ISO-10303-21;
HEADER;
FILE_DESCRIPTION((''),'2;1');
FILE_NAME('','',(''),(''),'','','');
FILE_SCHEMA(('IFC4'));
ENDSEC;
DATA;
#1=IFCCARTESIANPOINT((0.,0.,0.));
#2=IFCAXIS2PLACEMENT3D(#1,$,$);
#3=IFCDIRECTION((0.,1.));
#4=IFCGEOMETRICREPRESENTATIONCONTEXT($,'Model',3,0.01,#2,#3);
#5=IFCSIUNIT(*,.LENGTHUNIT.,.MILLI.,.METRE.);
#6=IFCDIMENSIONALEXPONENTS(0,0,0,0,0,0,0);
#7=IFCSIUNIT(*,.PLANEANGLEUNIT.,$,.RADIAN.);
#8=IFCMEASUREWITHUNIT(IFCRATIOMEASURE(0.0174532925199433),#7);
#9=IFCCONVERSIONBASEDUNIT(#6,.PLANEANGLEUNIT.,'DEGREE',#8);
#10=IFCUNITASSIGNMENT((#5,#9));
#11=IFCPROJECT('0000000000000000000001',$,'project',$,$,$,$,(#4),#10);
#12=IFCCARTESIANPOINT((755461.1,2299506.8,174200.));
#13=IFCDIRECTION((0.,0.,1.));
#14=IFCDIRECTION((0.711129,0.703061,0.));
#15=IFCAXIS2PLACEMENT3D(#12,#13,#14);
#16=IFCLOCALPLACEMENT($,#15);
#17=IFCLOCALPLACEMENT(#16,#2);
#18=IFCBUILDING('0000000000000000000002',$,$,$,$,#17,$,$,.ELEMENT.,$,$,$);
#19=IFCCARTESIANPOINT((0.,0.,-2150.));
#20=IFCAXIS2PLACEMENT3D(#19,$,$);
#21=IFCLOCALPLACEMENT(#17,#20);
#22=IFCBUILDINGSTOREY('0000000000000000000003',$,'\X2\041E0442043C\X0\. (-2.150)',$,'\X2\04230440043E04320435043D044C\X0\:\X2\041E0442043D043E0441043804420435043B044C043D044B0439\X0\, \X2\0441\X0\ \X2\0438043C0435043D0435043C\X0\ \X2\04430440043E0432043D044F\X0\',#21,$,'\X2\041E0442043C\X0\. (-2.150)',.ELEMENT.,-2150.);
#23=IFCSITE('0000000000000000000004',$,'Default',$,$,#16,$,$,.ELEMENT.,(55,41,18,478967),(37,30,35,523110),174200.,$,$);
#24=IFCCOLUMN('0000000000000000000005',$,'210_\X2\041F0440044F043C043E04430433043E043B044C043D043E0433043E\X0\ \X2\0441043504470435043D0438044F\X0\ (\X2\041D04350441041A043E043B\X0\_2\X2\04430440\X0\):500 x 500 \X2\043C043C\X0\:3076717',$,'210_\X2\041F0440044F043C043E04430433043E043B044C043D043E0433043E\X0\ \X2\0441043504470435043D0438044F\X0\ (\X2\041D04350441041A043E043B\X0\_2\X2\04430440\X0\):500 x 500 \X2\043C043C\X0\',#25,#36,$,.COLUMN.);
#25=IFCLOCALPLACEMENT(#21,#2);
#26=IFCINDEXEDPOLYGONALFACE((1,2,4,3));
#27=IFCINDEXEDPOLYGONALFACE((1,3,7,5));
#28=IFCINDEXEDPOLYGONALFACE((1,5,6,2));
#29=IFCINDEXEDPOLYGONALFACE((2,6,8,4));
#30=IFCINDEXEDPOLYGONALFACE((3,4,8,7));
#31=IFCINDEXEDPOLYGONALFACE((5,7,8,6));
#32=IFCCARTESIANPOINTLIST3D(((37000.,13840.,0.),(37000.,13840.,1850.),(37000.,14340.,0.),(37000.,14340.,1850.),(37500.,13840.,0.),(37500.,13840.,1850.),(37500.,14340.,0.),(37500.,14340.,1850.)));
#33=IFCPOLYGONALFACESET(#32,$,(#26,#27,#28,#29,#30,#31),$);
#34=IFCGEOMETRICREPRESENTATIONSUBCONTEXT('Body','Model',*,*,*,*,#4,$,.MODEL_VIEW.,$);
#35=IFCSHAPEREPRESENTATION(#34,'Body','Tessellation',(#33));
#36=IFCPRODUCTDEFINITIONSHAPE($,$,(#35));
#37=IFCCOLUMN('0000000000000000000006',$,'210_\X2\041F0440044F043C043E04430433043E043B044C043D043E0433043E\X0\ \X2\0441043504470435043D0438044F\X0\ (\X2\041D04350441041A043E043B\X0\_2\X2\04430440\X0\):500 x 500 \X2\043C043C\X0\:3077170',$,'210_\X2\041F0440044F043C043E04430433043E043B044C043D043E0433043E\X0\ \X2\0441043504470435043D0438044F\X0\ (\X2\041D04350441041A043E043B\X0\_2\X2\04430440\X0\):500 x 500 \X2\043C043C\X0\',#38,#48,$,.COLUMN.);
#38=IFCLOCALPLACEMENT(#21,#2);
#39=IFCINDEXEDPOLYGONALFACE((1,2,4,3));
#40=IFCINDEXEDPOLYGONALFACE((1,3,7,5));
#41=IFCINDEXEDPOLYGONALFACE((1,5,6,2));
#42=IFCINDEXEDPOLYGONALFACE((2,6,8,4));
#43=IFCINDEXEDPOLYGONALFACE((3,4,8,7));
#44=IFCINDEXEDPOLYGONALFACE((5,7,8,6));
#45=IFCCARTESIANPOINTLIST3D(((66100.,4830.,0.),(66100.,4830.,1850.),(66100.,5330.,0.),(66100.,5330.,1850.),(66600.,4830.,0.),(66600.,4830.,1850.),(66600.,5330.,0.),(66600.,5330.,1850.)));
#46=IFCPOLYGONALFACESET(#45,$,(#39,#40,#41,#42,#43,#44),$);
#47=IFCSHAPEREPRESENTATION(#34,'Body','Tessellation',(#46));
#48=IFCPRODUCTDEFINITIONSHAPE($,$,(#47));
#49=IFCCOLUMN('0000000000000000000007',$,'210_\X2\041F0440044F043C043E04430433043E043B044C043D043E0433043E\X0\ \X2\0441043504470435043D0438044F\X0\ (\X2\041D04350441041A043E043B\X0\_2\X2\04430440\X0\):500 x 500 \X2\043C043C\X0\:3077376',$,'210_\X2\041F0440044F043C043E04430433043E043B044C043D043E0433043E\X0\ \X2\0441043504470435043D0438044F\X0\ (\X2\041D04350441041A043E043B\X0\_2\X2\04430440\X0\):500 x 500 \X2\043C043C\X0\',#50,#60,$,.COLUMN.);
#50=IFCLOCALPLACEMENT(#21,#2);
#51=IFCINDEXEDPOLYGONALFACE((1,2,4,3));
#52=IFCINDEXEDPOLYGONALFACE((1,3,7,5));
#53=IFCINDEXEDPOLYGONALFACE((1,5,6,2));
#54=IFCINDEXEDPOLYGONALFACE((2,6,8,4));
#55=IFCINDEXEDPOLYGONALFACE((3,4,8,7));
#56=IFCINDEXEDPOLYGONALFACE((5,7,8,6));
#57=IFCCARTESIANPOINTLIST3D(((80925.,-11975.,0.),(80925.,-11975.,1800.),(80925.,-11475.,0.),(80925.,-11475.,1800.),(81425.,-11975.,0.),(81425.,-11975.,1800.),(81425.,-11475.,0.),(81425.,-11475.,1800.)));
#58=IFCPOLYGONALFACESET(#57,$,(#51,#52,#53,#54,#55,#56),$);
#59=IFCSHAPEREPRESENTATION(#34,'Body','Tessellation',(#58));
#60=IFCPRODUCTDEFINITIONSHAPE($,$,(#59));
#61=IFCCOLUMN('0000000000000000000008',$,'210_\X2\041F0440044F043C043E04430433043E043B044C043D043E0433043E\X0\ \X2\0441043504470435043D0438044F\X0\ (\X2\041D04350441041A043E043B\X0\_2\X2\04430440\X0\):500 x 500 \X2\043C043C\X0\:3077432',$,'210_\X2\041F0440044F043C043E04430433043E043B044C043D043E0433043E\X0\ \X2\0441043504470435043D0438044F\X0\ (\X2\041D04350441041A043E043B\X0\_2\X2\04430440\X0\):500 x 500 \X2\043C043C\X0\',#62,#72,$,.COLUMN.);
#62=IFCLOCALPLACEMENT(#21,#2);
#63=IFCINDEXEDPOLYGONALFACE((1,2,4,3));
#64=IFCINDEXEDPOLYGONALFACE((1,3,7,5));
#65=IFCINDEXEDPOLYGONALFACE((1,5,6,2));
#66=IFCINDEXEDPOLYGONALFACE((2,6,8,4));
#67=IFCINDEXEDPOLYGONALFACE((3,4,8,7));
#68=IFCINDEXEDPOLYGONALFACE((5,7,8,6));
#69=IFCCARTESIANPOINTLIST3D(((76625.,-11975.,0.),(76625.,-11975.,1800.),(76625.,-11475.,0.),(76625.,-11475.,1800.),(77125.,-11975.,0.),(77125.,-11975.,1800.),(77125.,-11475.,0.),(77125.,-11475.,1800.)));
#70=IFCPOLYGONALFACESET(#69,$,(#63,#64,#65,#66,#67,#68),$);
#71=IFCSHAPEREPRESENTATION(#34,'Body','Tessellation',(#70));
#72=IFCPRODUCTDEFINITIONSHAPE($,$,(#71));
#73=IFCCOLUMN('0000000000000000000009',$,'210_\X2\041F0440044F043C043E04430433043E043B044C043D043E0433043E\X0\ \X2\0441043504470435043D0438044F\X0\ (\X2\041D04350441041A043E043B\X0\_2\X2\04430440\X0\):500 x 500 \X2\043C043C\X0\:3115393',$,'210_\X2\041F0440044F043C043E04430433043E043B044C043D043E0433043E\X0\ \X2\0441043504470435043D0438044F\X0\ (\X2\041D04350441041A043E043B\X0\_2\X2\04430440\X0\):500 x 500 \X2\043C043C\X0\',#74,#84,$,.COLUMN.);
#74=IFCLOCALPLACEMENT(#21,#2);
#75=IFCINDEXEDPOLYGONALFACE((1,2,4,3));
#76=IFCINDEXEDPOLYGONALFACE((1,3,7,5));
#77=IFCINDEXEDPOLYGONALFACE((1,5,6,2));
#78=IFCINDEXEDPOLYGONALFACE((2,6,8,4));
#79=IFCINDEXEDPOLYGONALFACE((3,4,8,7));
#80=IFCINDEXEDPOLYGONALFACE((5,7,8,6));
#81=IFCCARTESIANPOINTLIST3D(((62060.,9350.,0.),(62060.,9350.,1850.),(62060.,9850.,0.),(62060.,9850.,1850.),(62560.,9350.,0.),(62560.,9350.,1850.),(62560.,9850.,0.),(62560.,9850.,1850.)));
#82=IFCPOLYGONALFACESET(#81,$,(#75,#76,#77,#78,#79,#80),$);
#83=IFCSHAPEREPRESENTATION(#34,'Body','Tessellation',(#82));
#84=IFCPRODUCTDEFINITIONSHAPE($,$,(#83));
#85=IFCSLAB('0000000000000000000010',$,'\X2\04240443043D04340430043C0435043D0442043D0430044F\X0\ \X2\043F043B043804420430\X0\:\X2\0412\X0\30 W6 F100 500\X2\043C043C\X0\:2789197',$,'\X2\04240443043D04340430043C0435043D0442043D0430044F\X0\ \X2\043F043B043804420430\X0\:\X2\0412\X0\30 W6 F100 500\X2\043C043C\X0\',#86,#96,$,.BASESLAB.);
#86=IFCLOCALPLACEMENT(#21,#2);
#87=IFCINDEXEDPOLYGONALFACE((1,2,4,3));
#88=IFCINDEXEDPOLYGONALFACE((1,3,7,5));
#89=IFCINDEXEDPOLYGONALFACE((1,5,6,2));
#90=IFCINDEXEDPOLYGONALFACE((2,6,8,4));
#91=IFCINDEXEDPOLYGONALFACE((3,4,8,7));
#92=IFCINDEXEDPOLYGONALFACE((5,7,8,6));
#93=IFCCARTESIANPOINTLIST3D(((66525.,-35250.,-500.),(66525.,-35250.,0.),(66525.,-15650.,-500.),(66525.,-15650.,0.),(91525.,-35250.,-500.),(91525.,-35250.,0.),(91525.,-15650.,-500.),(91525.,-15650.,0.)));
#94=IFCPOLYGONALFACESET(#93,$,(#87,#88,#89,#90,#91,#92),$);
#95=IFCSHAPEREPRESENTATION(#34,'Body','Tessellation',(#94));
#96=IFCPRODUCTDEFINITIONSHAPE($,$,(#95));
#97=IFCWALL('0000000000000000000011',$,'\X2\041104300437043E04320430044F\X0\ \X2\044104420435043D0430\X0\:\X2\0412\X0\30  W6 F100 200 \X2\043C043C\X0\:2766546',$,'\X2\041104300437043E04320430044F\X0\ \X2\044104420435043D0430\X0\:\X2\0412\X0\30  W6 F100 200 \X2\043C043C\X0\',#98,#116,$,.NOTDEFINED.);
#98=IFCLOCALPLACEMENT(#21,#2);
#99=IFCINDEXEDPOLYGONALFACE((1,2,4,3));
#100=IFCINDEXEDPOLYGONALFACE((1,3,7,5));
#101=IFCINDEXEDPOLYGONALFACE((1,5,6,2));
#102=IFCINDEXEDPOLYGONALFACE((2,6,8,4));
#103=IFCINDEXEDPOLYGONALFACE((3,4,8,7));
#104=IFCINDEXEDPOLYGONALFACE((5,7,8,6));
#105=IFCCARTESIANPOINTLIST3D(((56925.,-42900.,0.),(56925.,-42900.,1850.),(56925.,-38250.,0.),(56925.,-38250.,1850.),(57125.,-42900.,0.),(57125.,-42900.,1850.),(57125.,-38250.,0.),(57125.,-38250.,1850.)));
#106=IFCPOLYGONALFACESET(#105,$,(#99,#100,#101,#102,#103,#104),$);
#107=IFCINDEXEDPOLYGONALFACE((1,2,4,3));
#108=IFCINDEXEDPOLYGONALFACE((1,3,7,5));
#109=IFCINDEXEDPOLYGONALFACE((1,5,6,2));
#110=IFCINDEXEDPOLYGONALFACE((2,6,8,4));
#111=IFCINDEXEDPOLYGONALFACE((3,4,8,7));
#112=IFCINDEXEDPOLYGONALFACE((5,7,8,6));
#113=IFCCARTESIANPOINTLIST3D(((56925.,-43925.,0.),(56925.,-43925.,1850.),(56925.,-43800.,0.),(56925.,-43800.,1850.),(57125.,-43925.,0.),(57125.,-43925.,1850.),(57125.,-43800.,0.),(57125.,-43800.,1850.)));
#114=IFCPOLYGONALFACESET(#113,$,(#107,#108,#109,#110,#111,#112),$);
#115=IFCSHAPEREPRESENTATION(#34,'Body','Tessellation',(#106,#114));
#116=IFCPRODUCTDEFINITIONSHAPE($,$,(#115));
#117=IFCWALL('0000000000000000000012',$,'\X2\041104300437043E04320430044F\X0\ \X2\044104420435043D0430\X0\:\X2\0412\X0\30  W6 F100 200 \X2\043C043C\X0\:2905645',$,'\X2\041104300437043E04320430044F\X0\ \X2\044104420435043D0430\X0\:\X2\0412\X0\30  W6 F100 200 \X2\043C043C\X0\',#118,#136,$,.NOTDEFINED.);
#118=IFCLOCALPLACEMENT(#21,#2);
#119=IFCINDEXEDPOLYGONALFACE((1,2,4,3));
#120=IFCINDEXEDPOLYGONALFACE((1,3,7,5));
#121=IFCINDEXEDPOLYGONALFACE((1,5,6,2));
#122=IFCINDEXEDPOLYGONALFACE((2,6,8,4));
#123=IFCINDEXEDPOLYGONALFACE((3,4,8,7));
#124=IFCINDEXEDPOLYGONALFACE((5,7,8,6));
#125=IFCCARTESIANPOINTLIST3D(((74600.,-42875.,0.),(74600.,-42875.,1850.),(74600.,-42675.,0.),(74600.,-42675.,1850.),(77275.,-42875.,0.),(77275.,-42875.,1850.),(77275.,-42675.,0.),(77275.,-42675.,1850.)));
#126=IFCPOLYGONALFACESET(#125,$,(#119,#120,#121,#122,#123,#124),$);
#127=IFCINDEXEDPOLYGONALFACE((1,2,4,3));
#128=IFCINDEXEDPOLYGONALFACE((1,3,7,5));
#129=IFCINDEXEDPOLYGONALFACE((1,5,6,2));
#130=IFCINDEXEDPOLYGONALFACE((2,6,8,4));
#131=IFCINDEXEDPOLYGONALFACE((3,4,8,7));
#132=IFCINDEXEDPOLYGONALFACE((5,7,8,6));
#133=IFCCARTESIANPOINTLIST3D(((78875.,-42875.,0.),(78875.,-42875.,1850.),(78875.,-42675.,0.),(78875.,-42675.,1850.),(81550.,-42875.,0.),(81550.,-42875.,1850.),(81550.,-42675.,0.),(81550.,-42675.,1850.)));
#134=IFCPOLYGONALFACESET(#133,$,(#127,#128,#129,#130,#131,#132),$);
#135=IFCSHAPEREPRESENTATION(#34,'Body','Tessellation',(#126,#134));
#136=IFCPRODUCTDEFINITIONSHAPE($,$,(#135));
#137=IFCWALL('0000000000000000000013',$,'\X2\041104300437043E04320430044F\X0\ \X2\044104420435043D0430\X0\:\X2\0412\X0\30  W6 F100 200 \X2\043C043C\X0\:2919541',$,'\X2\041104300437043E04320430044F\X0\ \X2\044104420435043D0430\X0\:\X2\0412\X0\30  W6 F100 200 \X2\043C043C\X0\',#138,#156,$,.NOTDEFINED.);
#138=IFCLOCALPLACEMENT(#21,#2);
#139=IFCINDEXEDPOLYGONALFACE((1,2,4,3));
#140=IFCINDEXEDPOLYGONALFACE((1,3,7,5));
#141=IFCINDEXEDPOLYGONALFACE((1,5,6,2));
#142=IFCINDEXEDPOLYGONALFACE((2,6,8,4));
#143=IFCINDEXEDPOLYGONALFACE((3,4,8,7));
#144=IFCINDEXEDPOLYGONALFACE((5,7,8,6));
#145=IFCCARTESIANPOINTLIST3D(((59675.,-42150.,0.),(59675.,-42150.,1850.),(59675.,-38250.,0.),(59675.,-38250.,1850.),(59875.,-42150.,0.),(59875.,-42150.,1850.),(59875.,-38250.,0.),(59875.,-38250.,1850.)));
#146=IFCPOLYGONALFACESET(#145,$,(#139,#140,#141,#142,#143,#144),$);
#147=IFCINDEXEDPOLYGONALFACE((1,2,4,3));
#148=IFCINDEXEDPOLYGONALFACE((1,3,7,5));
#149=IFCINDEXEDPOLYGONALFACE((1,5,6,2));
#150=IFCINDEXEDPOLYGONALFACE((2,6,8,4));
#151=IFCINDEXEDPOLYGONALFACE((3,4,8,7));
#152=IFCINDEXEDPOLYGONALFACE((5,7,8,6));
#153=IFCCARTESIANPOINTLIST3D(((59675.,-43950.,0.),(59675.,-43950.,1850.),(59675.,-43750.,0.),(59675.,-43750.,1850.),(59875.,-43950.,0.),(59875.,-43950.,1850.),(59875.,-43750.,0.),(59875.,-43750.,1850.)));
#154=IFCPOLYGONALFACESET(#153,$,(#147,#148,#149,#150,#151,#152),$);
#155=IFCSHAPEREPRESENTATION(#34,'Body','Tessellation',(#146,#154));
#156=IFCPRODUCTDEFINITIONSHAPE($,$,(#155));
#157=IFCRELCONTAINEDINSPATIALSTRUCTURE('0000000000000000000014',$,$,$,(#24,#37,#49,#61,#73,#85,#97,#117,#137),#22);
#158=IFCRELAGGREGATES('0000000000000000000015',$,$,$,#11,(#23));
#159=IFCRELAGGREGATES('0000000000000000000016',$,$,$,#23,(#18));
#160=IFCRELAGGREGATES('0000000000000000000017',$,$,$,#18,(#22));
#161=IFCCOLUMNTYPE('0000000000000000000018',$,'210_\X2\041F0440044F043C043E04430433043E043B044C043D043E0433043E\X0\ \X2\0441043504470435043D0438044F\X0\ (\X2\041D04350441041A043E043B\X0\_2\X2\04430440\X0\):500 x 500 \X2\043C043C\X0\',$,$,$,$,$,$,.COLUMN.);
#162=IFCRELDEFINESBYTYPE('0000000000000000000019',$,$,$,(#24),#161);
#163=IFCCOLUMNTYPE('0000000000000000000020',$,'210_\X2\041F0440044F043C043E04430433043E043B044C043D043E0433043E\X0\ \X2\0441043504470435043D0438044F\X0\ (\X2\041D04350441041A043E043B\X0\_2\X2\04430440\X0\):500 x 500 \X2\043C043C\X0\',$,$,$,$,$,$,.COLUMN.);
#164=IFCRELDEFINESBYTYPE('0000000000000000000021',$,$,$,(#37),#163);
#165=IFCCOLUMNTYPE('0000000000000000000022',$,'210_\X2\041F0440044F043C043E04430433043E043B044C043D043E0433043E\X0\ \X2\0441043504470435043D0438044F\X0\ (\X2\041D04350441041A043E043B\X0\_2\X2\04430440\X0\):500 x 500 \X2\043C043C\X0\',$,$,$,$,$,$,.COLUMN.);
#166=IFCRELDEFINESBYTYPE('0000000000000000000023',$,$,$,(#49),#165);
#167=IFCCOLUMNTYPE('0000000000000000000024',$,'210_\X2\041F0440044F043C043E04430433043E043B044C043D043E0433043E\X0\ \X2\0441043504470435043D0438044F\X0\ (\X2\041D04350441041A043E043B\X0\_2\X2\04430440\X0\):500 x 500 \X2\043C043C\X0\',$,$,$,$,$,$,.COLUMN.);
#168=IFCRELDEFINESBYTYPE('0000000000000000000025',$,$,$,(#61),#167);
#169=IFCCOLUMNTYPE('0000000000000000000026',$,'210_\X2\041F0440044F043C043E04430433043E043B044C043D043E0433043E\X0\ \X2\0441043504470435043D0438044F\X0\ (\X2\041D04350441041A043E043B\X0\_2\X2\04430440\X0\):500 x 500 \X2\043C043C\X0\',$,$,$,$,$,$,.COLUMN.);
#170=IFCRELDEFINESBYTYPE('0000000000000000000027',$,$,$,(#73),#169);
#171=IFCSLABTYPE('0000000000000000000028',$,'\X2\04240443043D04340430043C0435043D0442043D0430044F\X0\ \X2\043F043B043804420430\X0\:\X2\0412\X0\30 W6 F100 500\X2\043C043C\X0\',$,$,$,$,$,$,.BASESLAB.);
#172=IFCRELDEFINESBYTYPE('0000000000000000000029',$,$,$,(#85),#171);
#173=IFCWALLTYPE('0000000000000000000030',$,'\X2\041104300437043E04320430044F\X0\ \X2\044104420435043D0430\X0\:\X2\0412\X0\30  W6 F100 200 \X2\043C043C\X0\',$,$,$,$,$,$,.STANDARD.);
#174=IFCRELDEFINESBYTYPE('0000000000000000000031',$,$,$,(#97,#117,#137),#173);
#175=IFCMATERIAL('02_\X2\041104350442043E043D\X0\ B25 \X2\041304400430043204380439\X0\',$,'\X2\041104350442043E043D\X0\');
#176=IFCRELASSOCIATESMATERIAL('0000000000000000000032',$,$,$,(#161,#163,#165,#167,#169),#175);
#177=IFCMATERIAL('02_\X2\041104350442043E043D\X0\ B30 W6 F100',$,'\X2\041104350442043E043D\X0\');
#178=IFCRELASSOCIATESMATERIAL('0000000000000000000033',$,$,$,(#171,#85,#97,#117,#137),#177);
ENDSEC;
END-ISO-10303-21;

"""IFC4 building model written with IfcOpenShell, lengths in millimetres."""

from ifc_helpers import new_model, entity, si_unit, converted_unit, direction, frame, origin, place, context, subcontext, project, spatial, indexed_curve, outline, extrude, source, transform, mapped, material, type_object, type_shapes, element, save


model = new_model("IFC4")

# Units and contexts
model_context = context("Model", 3, precision=0.01, world=origin(), true_north=direction((0.0, 1.0)))
body_context = subcontext(model_context, "Body", "Model", "MODEL_VIEW")
ifc_project = project(units=[si_unit("LENGTHUNIT", "METRE", prefix="MILLI"), converted_unit("PLANEANGLEUNIT", "DEGREE", entity("IfcRatioMeasure", 0.0174532925199433), si_unit("PLANEANGLEUNIT", "RADIAN"), dimensions=[0, 0, 0, 0, 0, 0, 0])], contexts=[model_context])

# Site, building, storey
site_placement = place(None, frame((755461.1, 2299506.8, 174200.0), z_axis=(0.0, 0.0, 1.0), x_axis=(0.711129, 0.703061, 0.0)))
site = spatial("IfcSite", under=ifc_project, at=site_placement, Name="Default", CompositionType="ELEMENT", RefLatitude=(55, 41, 18, 478967), RefLongitude=(37, 30, 35, 523110), RefElevation=174200.0)
building_placement = place(site_placement, origin())
building = spatial("IfcBuilding", under=site, at=building_placement, CompositionType="ELEMENT")
storey_placement = place(building_placement, frame((0.0, 0.0, -2150.0)))
storey = spatial("IfcBuildingStorey", under=building, at=storey_placement, Name="Отм. (-2.150)", ObjectType="Уровень:Относительный, с именем уровня", LongName="Отм. (-2.150)", CompositionType="ELEMENT", Elevation=-2150.0)

# Columns
ifc_material_1 = material(Name="02_Бетон B25 Гравий", Category="Бетон")
column_type_1 = type_object("IfcColumnType", Name="210_Прямоугольного сечения (НесКол_2ур):500 x 500 мм", PredefinedType="COLUMN", material=ifc_material_1)
shared_shape_1 = source(origin(), body_context, "Body", "SweptSolid", [
    extrude(outline(indexed_curve([(-250.0, -250.0), (250.0, -250.0), (250.0, 250.0), (-250.0, 250.0), (-250.0, -250.0)], self_intersect=False)), frame((37250.0, 14090.0, -2150.0), z_axis=(0.0, 0.0, 1.0), x_axis=(0.0, -1.0, 0.0)), (0.0, 0.0, 1.0), 1850.0),
])
type_shapes(column_type_1, [shared_shape_1])
column_1_placement = place(storey_placement, frame((0.0, 0.0, 2150.0)))
element("IfcColumn", 1, at=column_1_placement, inside=storey, type_object=column_type_1, Name="210_Прямоугольного сечения (НесКол_2ур):500 x 500 мм:3076717", ObjectType="210_Прямоугольного сечения (НесКол_2ур):500 x 500 мм", PredefinedType="COLUMN", context=body_context, shape_type="MappedRepresentation", body=[
    mapped(shared_shape_1, transform((0.0, 0.0, 0.0), scale=1.0)),
])
column_type_2 = type_object("IfcColumnType", Name="210_Прямоугольного сечения (НесКол_2ур):500 x 500 мм", PredefinedType="COLUMN", material=ifc_material_1)
shared_shape_2 = source(origin(), body_context, "Body", "SweptSolid", [
    extrude(outline(indexed_curve([(-250.0, -250.0), (250.0, -250.0), (250.0, 250.0), (-250.0, 250.0), (-250.0, -250.0)], self_intersect=False)), frame((66350.0, 5080.0, -2150.0), z_axis=(0.0, 0.0, 1.0), x_axis=(0.0, -1.0, 0.0)), (0.0, 0.0, 1.0), 1850.0),
])
type_shapes(column_type_2, [shared_shape_2])
column_2_placement = place(storey_placement, frame((0.0, 0.0, 2150.0)))
element("IfcColumn", 2, at=column_2_placement, inside=storey, type_object=column_type_2, Name="210_Прямоугольного сечения (НесКол_2ур):500 x 500 мм:3077170", ObjectType="210_Прямоугольного сечения (НесКол_2ур):500 x 500 мм", PredefinedType="COLUMN", context=body_context, shape_type="MappedRepresentation", body=[
    mapped(shared_shape_2, transform((0.0, 0.0, 0.0), scale=1.0)),
])
column_type_3 = type_object("IfcColumnType", Name="210_Прямоугольного сечения (НесКол_2ур):500 x 500 мм", PredefinedType="COLUMN", material=ifc_material_1)
shared_shape_3 = source(origin(), body_context, "Body", "SweptSolid", [
    extrude(outline(indexed_curve([(-250.0, -250.0), (250.0, -250.0), (250.0, 250.0), (-250.0, 250.0), (-250.0, -250.0)], self_intersect=False)), frame((81175.0, -11725.0, -2150.0), z_axis=(0.0, 0.0, 1.0), x_axis=(0.0, -1.0, 0.0)), (0.0, 0.0, 1.0), 1800.0),
])
type_shapes(column_type_3, [shared_shape_3])
column_3_placement = place(storey_placement, frame((0.0, 0.0, 2150.0)))
element("IfcColumn", 3, at=column_3_placement, inside=storey, type_object=column_type_3, Name="210_Прямоугольного сечения (НесКол_2ур):500 x 500 мм:3077376", ObjectType="210_Прямоугольного сечения (НесКол_2ур):500 x 500 мм", PredefinedType="COLUMN", context=body_context, shape_type="MappedRepresentation", body=[
    mapped(shared_shape_3, transform((0.0, 0.0, 0.0), scale=1.0)),
])
column_type_4 = type_object("IfcColumnType", Name="210_Прямоугольного сечения (НесКол_2ур):500 x 500 мм", PredefinedType="COLUMN", material=ifc_material_1)
shared_shape_4 = source(origin(), body_context, "Body", "SweptSolid", [
    extrude(outline(indexed_curve([(-250.0, -250.0), (250.0, -250.0), (250.0, 250.0), (-250.0, 250.0), (-250.0, -250.0)], self_intersect=False)), frame((76875.0, -11725.0, -2150.0), z_axis=(0.0, 0.0, 1.0), x_axis=(0.0, -1.0, 0.0)), (0.0, 0.0, 1.0), 1800.0),
])
type_shapes(column_type_4, [shared_shape_4])
column_4_placement = place(storey_placement, frame((0.0, 0.0, 2150.0)))
element("IfcColumn", 4, at=column_4_placement, inside=storey, type_object=column_type_4, Name="210_Прямоугольного сечения (НесКол_2ур):500 x 500 мм:3077432", ObjectType="210_Прямоугольного сечения (НесКол_2ур):500 x 500 мм", PredefinedType="COLUMN", context=body_context, shape_type="MappedRepresentation", body=[
    mapped(shared_shape_4, transform((0.0, 0.0, 0.0), scale=1.0)),
])
column_type_5 = type_object("IfcColumnType", Name="210_Прямоугольного сечения (НесКол_2ур):500 x 500 мм", PredefinedType="COLUMN", material=ifc_material_1)
shared_shape_5 = source(origin(), body_context, "Body", "SweptSolid", [
    extrude(outline(indexed_curve([(-250.0, -250.0), (250.0, -250.0), (250.0, 250.0), (-250.0, 250.0), (-250.0, -250.0)], self_intersect=False)), frame((62310.0, 9600.0, -2150.0), z_axis=(0.0, 0.0, 1.0), x_axis=(0.0, -1.0, 0.0)), (0.0, 0.0, 1.0), 1850.0),
])
type_shapes(column_type_5, [shared_shape_5])
column_5_placement = place(storey_placement, frame((0.0, 0.0, 2150.0)))
element("IfcColumn", 5, at=column_5_placement, inside=storey, type_object=column_type_5, Name="210_Прямоугольного сечения (НесКол_2ур):500 x 500 мм:3115393", ObjectType="210_Прямоугольного сечения (НесКол_2ур):500 x 500 мм", PredefinedType="COLUMN", context=body_context, shape_type="MappedRepresentation", body=[
    mapped(shared_shape_5, transform((0.0, 0.0, 0.0), scale=1.0)),
])

# Slab
ifc_material_2 = material(Name="02_Бетон B30 W6 F100", Category="Бетон")
slab_type_1 = type_object("IfcSlabType", Name="Фундаментная плита:В30 W6 F100 500мм", PredefinedType="BASESLAB", material=ifc_material_2)
slab_1_placement = place(storey_placement, origin())
element("IfcSlab", 6, at=slab_1_placement, inside=storey, type_object=slab_type_1, material=ifc_material_2, Name="Фундаментная плита:В30 W6 F100 500мм:2789197", ObjectType="Фундаментная плита:В30 W6 F100 500мм", PredefinedType="BASESLAB", context=body_context, shape_type="SweptSolid", body=[
    extrude(outline(indexed_curve([(-9800.0, -12500.0), (9800.0, -12500.0), (9800.0, 12500.0), (-9800.0, 12500.0), (-9800.0, -12500.0)], self_intersect=False)), frame((79025.0, -25450.0, 0.0), z_axis=(0.0, 0.0, -1.0), x_axis=(0.0, 1.0, 0.0)), (0.0, 0.0, 1.0), 500.0),
])

# Walls
wall_type = type_object("IfcWallType", Name="Базовая стена:В30  W6 F100 200 мм", PredefinedType="STANDARD")
wall_1_placement = place(storey_placement, frame((57025.0, -38250.0, 0.0), z_axis=(0.0, 0.0, 1.0), x_axis=(0.0, -1.0, 0.0)))
element("IfcWall", 7, at=wall_1_placement, inside=storey, type_object=wall_type, material=ifc_material_2, Name="Базовая стена:В30  W6 F100 200 мм:2766546", ObjectType="Базовая стена:В30  W6 F100 200 мм", PredefinedType="NOTDEFINED", context=body_context, shape_type="SweptSolid", body=[
    extrude(outline(indexed_curve([(-2325.0, -100.0), (2325.0, -100.0), (2325.0, 100.0), (-2325.0, 100.0), (-2325.0, -100.0)], self_intersect=False)), frame((2325.0, 0.0, 0.0)), (0.0, 0.0, 1.0), 1850.0),
    extrude(outline(indexed_curve([(-62.5, -100.0), (62.5, -100.0), (62.5, 100.0), (-62.5, 100.0), (-62.5, -100.0)], self_intersect=False)), frame((5612.5, 0.0, 0.0), z_axis=(0.0, 0.0, 1.0), x_axis=(-1.0, 0.0, 0.0)), (0.0, 0.0, 1.0), 1850.0),
])
wall_2_placement = place(storey_placement, frame((74600.0, -42775.0, 0.0)))
element("IfcWall", 8, at=wall_2_placement, inside=storey, type_object=wall_type, material=ifc_material_2, Name="Базовая стена:В30  W6 F100 200 мм:2905645", ObjectType="Базовая стена:В30  W6 F100 200 мм", PredefinedType="NOTDEFINED", context=body_context, shape_type="SweptSolid", body=[
    extrude(outline(indexed_curve([(-1337.5, -100.0), (1337.5, -100.0), (1337.5, 100.0), (-1337.5, 100.0), (-1337.5, -100.0)], self_intersect=False)), frame((1337.5, 0.0, 0.0)), (0.0, 0.0, 1.0), 1850.0),
    extrude(outline(indexed_curve([(-1337.5, -100.0), (1337.5, -100.0), (1337.5, 100.0), (-1337.5, 100.0), (-1337.5, -100.0)], self_intersect=False)), frame((5612.5, 0.0, 0.0), z_axis=(0.0, 0.0, 1.0), x_axis=(-1.0, 0.0, 0.0)), (0.0, 0.0, 1.0), 1850.0),
])
wall_3_placement = place(storey_placement, frame((59775.0, -38250.0, 0.0), z_axis=(0.0, 0.0, 1.0), x_axis=(0.0, -1.0, 0.0)))
element("IfcWall", 9, at=wall_3_placement, inside=storey, type_object=wall_type, material=ifc_material_2, Name="Базовая стена:В30  W6 F100 200 мм:2919541", ObjectType="Базовая стена:В30  W6 F100 200 мм", PredefinedType="NOTDEFINED", context=body_context, shape_type="SweptSolid", body=[
    extrude(outline(indexed_curve([(-1950.0, -100.0), (1950.0, -100.0), (1950.0, 100.0), (-1950.0, 100.0), (-1950.0, -100.0)], self_intersect=False)), frame((1950.0, 0.0, 0.0)), (0.0, 0.0, 1.0), 1850.0),
    extrude(outline(indexed_curve([(-100.0, -100.0), (100.0, -100.0), (100.0, 100.0), (-100.0, 100.0), (-100.0, -100.0)], self_intersect=False)), frame((5600.0, 0.0, 0.0), z_axis=(0.0, 0.0, 1.0), x_axis=(-1.0, 0.0, 0.0)), (0.0, 0.0, 1.0), 1850.0),
])

save(model, "model.ifc")
